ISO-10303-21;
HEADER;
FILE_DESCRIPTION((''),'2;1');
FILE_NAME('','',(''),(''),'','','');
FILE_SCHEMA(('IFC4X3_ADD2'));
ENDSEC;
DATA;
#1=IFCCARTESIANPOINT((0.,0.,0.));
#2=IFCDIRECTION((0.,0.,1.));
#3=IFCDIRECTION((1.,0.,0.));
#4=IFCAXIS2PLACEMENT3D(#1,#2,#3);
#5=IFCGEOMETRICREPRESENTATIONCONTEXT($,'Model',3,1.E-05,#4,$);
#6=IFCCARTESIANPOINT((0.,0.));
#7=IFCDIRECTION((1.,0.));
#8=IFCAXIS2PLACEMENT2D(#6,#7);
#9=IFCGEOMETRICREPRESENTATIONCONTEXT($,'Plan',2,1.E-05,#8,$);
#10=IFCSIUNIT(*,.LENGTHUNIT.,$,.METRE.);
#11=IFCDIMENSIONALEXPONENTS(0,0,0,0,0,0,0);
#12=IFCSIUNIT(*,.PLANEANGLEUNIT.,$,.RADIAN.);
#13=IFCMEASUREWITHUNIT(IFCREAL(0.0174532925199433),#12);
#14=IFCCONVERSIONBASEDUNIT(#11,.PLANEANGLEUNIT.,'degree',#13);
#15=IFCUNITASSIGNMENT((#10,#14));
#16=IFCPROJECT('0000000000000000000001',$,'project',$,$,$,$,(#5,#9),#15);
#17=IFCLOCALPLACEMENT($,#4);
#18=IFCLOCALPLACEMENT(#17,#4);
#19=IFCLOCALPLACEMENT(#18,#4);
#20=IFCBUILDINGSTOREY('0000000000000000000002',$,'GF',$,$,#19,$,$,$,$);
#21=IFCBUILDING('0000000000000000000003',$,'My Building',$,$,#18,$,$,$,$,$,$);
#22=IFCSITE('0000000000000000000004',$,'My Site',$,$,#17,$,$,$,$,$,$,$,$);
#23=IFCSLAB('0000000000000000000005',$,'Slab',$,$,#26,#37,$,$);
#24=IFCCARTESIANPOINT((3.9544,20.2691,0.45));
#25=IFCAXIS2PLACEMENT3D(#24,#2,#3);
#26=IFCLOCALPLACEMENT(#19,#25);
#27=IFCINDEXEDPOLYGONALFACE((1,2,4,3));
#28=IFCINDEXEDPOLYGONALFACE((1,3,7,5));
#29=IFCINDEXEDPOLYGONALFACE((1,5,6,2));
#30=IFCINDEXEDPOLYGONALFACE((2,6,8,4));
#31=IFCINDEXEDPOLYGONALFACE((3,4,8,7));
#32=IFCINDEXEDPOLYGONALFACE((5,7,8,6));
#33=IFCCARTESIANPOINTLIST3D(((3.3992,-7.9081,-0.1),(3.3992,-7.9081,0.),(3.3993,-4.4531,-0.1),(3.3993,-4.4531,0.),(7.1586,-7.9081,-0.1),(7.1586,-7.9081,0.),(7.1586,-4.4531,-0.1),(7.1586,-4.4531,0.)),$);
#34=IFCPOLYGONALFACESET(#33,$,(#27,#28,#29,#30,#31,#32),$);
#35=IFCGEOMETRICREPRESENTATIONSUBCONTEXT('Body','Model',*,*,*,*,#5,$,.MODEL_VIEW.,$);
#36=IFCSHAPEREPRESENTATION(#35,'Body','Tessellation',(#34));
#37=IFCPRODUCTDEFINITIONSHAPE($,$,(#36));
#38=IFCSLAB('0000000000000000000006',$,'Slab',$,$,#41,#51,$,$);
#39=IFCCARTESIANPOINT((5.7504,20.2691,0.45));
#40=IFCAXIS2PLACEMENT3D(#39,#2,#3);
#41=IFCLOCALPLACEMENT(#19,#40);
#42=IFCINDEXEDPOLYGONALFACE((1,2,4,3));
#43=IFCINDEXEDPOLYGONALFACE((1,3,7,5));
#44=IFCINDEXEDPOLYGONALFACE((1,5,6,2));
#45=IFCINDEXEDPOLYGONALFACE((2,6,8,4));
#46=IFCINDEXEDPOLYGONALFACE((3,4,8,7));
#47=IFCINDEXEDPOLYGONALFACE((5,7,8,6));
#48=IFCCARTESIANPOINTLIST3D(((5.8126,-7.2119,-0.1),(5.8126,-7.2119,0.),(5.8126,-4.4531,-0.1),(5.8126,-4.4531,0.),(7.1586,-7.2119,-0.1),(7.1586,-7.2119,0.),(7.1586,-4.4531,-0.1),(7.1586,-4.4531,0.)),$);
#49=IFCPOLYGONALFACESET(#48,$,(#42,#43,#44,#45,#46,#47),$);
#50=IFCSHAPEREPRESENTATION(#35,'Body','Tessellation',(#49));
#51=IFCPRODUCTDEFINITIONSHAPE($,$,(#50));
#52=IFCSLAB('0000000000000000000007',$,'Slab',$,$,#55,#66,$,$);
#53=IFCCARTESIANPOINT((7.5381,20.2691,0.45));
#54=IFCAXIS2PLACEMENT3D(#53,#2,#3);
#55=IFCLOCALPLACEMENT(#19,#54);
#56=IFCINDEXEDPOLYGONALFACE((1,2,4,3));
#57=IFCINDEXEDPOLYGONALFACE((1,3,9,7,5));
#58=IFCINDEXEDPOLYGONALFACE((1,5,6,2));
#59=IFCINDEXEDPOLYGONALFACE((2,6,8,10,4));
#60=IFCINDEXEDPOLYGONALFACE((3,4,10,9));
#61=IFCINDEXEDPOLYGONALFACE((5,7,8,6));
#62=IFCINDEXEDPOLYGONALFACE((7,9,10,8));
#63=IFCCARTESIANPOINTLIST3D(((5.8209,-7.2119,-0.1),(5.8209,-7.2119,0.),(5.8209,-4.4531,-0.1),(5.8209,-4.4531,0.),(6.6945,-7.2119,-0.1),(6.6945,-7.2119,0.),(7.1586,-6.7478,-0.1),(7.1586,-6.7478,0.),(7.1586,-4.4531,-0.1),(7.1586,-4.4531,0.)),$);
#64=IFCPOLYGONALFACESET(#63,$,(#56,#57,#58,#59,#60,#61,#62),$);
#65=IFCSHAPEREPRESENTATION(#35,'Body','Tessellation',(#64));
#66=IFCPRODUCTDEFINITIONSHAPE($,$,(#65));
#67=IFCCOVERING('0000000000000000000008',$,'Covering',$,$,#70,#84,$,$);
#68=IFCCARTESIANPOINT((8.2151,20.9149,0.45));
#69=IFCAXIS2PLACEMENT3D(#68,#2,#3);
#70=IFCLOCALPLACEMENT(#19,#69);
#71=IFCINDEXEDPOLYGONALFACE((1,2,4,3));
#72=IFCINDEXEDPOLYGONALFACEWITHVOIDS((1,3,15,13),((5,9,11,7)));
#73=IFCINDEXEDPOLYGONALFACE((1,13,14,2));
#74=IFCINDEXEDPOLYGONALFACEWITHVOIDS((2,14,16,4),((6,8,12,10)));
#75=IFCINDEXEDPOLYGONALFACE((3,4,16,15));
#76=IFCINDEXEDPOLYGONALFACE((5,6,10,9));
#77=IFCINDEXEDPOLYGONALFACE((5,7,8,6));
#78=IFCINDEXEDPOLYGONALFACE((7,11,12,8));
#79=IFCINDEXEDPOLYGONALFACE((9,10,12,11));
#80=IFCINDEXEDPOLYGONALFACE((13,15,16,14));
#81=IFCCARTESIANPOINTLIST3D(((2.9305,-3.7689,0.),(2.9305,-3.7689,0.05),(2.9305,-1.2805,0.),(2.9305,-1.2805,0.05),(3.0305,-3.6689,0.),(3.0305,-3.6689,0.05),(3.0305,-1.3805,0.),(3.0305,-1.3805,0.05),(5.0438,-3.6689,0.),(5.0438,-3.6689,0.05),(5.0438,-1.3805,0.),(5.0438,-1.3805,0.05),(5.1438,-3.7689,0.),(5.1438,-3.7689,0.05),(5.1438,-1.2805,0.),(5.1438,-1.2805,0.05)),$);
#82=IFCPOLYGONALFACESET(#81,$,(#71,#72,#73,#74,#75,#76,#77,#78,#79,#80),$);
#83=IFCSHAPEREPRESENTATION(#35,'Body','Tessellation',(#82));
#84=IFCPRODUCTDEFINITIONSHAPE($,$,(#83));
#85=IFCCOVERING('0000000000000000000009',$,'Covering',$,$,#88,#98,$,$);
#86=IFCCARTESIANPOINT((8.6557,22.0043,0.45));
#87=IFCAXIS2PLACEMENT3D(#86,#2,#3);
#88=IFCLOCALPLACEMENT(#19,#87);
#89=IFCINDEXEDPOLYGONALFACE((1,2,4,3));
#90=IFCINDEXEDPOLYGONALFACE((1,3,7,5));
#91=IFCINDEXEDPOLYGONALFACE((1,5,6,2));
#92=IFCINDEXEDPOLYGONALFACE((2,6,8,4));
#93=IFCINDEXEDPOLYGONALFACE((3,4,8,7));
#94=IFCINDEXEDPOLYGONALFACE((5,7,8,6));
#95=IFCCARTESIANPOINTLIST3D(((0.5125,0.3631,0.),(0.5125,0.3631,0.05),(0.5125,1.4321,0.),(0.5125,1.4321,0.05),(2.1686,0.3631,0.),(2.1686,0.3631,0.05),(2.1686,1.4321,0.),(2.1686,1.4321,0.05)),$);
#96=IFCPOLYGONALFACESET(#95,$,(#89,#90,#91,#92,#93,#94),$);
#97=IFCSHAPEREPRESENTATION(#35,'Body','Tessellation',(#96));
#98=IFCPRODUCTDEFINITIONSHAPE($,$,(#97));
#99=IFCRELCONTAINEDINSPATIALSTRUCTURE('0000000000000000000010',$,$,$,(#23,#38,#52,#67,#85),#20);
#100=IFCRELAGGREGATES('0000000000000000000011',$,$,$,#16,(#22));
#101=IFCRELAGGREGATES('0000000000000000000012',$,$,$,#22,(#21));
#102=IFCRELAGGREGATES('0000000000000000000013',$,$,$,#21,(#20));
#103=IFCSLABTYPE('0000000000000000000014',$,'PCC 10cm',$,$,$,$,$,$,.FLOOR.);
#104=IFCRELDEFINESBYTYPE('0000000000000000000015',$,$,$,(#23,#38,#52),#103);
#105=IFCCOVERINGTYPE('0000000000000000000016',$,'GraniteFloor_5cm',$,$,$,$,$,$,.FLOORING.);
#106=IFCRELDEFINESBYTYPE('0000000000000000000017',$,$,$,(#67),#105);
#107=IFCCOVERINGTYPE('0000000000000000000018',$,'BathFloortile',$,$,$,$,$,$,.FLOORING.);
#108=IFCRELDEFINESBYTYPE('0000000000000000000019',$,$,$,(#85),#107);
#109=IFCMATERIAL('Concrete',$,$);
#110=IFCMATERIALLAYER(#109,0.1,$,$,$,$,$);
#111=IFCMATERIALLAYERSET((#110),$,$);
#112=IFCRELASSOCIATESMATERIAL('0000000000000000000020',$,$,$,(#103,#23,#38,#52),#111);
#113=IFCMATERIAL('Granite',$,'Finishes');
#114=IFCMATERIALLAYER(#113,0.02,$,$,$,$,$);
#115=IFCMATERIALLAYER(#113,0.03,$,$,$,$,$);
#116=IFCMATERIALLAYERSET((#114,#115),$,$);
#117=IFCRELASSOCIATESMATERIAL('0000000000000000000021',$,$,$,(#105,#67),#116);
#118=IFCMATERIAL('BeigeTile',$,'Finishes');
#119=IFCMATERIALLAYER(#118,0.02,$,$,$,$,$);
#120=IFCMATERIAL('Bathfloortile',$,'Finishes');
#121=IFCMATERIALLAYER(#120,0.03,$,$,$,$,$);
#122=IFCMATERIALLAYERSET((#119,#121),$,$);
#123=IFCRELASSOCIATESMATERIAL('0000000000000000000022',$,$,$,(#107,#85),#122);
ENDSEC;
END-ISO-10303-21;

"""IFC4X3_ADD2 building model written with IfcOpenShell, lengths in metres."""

from ifc_helpers import new_model, entity, si_unit, converted_unit, frame, origin_with_axes, origin_2d_with_axis, place, context, subcontext, project, spatial, indexed_curve, outline, extrude, material, layer, layer_set, layer_usage, type_object, element, save


model = new_model("IFC4X3_ADD2")

# Units and contexts
model_context = context("Model", 3, precision=1e-05, world=origin_with_axes())
plan_context = context("Plan", 2, precision=1e-05, world=origin_2d_with_axis())
body_context_1 = subcontext(model_context, "Body", "Model", "MODEL_VIEW")
ifc_project = project(units=[si_unit("LENGTHUNIT", "METRE"), converted_unit("PLANEANGLEUNIT", "degree", entity("IfcReal", 0.0174532925199433), si_unit("PLANEANGLEUNIT", "RADIAN"), dimensions=[0, 0, 0, 0, 0, 0, 0])], contexts=[model_context, plan_context])

# Site, building, storey
site_placement = place(None, origin_with_axes())
site = spatial("IfcSite", under=ifc_project, at=site_placement, Name="My Site")
building_placement = place(site_placement, origin_with_axes())
building = spatial("IfcBuilding", under=site, at=building_placement, Name="My Building")
storey_placement = place(building_placement, origin_with_axes())
storey = spatial("IfcBuildingStorey", under=building, at=storey_placement, Name="GF")

# Slabs
ifc_material_1 = material(Name="Concrete")
ifc_layer_1 = layer(ifc_material_1, 0.1)
ifc_layer_set_1 = layer_set([ifc_layer_1])
ifc_layer_usage_1 = layer_usage(ifc_layer_set_1, "AXIS3", "POSITIVE", -0.1)
slab_type = type_object("IfcSlabType", Name="PCC 10cm", PredefinedType="FLOOR", material=ifc_layer_set_1)
slab_1_placement = place(storey_placement, frame((3.9544, 20.2691, 0.45), z_axis=(0.0, 0.0, 1.0), x_axis=(1.0, 0.0, 0.0)))
element("IfcSlab", 1, at=slab_1_placement, inside=storey, type_object=slab_type, material=ifc_layer_usage_1, Name="Slab", context=body_context_1, shape_type="SweptSolid", body=[
    extrude(outline(indexed_curve([(3.3992, -7.9081), (7.1586, -7.9081), (7.1586, -4.4531), (3.3993, -4.4531), (3.3992, -7.9081)])), frame((0.0, 0.0, -0.1), z_axis=(0.0, 0.0, 1.0), x_axis=(1.0, 0.0, 0.0)), (0.0, 0.0, 1.0), 0.1),
])
ifc_layer_usage_2 = layer_usage(ifc_layer_set_1, "AXIS3", "POSITIVE", -0.1)
slab_2_placement = place(storey_placement, frame((5.7504, 20.2691, 0.45), z_axis=(0.0, 0.0, 1.0), x_axis=(1.0, 0.0, 0.0)))
element("IfcSlab", 2, at=slab_2_placement, inside=storey, type_object=slab_type, material=ifc_layer_usage_2, Name="Slab", context=body_context_1, shape_type="SweptSolid", body=[
    extrude(outline(indexed_curve([(5.8126, -4.4531), (7.1586, -4.4531), (7.1586, -7.2119), (5.8126, -7.2119), (5.8126, -4.4531)])), frame((0.0, 0.0, -0.1), z_axis=(0.0, 0.0, 1.0), x_axis=(1.0, 0.0, 0.0)), (0.0, 0.0, 1.0), 0.1),
])
ifc_layer_usage_3 = layer_usage(ifc_layer_set_1, "AXIS3", "POSITIVE", -0.1)
slab_3_placement = place(storey_placement, frame((7.5381, 20.2691, 0.45), z_axis=(0.0, 0.0, 1.0), x_axis=(1.0, 0.0, 0.0)))
element("IfcSlab", 3, at=slab_3_placement, inside=storey, type_object=slab_type, material=ifc_layer_usage_3, Name="Slab", context=body_context_1, shape_type="SweptSolid", body=[
    extrude(outline(indexed_curve([(7.1586, -4.4531), (5.8209, -4.4531), (5.8209, -7.2119), (6.6945, -7.2119), (7.1586, -6.7478), (7.1586, -4.4531)])), frame((0.0, 0.0, -0.1), z_axis=(0.0, 0.0, 1.0), x_axis=(1.0, 0.0, 0.0)), (0.0, 0.0, 1.0), 0.1),
])

# Coverings
ifc_material_2 = material(Name="Granite", Category="Finishes")
ifc_layer_2 = layer(ifc_material_2, 0.02)
ifc_layer_3 = layer(ifc_material_2, 0.03)
ifc_layer_set_2 = layer_set([ifc_layer_2, ifc_layer_3])
ifc_layer_usage_4 = layer_usage(ifc_layer_set_2, "AXIS3", "POSITIVE", 0.0)
covering_type_1 = type_object("IfcCoveringType", Name="GraniteFloor_5cm", PredefinedType="FLOORING", material=ifc_layer_set_2)
covering_1_placement = place(storey_placement, frame((8.2151, 20.9149, 0.45), z_axis=(0.0, 0.0, 1.0), x_axis=(1.0, 0.0, 0.0)))
element("IfcCovering", 4, at=covering_1_placement, inside=storey, type_object=covering_type_1, material=ifc_layer_usage_4, Name="Covering", context=body_context_1, shape_type="SweptSolid", body=[
    extrude(outline(indexed_curve([(2.9305, -1.2805), (5.1438, -1.2805), (5.1438, -3.7689), (2.9305, -3.7689), (2.9305, -1.2805)]), holes=[indexed_curve([(3.0305, -1.3805), (5.0438, -1.3805), (5.0438, -3.6689), (3.0305, -3.6689), (3.0305, -1.3805)])]), origin_with_axes(), (0.0, 0.0, 1.0), 0.05),
])
ifc_material_3 = material(Name="BeigeTile", Category="Finishes")
ifc_layer_4 = layer(ifc_material_3, 0.02)
ifc_material_4 = material(Name="Bathfloortile", Category="Finishes")
ifc_layer_5 = layer(ifc_material_4, 0.03)
ifc_layer_set_3 = layer_set([ifc_layer_4, ifc_layer_5])
ifc_layer_usage_5 = layer_usage(ifc_layer_set_3, "AXIS3", "POSITIVE", 0.0)
covering_type_2 = type_object("IfcCoveringType", Name="BathFloortile", PredefinedType="FLOORING", material=ifc_layer_set_3)
covering_2_placement = place(storey_placement, frame((8.6557, 22.0043, 0.45), z_axis=(0.0, 0.0, 1.0), x_axis=(1.0, 0.0, 0.0)))
element("IfcCovering", 5, at=covering_2_placement, inside=storey, type_object=covering_type_2, material=ifc_layer_usage_5, Name="Covering", context=body_context_1, shape_type="SweptSolid", body=[
    extrude(outline(indexed_curve([(0.5125, 1.4321), (2.1686, 1.4321), (2.1686, 0.3631), (0.5125, 0.3631), (0.5125, 1.4321)])), origin_with_axes(), (0.0, 0.0, 1.0), 0.05),
])

save(model, "model.ifc")
